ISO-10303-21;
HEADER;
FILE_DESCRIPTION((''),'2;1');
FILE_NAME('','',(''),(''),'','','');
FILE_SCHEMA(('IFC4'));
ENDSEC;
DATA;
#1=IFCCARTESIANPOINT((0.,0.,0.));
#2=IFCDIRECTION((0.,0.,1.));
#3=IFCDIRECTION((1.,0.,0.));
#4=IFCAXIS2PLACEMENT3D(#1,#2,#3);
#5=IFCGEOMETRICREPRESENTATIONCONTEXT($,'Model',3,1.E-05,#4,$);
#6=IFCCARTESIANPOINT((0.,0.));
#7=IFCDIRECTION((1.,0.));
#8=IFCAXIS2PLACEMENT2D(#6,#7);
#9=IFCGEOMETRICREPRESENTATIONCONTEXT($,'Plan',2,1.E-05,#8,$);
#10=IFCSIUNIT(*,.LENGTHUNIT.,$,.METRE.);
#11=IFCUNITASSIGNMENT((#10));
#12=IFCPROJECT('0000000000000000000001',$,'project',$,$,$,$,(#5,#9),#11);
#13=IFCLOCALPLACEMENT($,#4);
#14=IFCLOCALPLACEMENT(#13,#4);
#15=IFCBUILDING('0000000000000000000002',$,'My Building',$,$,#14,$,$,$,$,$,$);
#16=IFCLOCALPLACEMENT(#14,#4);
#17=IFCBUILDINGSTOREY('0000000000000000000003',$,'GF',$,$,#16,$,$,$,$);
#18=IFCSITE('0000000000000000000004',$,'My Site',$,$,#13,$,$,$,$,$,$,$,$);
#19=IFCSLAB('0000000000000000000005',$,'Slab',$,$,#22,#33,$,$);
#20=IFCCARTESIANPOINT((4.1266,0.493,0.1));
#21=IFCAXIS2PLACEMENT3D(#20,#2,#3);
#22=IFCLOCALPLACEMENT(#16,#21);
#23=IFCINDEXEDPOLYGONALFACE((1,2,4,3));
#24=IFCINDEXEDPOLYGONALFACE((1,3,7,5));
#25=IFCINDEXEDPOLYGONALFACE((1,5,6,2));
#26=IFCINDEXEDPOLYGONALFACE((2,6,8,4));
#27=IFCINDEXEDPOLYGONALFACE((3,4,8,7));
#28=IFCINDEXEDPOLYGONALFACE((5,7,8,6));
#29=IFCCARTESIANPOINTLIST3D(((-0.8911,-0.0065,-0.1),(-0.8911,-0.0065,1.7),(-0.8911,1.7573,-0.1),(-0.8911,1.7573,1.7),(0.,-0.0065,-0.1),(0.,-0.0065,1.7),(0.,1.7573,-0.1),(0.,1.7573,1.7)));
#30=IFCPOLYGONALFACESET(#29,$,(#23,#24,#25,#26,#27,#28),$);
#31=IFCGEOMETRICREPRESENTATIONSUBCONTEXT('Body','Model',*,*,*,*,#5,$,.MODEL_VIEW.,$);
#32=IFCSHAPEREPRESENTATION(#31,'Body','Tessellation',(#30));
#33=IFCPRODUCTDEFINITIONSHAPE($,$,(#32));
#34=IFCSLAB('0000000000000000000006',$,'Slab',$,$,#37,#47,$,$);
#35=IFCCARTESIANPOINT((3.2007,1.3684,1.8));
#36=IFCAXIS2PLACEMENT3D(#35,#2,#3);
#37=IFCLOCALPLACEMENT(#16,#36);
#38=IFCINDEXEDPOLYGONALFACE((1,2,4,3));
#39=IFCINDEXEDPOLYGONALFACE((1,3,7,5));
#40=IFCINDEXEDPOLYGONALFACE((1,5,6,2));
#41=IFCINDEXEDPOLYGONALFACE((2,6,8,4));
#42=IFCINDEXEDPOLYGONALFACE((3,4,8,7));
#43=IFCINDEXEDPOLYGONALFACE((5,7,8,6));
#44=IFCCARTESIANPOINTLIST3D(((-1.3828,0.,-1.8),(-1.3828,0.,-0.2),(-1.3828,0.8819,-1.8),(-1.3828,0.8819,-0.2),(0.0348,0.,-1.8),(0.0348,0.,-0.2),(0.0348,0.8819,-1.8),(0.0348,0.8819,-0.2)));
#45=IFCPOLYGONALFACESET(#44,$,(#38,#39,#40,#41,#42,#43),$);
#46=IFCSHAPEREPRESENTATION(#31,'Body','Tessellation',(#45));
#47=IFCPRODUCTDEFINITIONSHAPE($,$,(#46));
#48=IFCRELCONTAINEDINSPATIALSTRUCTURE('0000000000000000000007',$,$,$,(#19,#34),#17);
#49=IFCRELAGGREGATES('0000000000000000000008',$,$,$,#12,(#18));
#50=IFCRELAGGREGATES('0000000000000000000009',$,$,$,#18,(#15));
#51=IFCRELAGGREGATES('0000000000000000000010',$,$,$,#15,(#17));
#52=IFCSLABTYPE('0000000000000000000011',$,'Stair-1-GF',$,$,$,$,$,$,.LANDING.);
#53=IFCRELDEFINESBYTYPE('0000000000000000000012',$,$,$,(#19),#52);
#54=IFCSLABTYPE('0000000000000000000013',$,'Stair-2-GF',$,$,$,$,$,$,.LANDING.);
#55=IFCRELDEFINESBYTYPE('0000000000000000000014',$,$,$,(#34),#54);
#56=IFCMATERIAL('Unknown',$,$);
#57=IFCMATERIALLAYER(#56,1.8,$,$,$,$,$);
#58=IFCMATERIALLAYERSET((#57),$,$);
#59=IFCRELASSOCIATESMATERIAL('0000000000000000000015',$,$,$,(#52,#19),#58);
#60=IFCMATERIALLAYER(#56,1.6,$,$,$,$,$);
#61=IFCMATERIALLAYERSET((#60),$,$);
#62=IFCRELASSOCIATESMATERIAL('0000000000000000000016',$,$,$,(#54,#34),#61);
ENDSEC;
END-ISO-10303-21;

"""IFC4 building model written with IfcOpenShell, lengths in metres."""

from ifc_helpers import new_model, si_unit, frame, origin_with_axes, origin_2d_with_axis, place, context, subcontext, project, spatial, indexed_curve, outline, extrude, material, layer, layer_set, layer_usage, type_object, element, save


model = new_model("IFC4")

# Units and contexts
model_context = context("Model", 3, precision=1e-05, world=origin_with_axes())
plan_context = context("Plan", 2, precision=1e-05, world=origin_2d_with_axis())
body_context_1 = subcontext(model_context, "Body", "Model", "MODEL_VIEW")
ifc_project = project(units=[si_unit("LENGTHUNIT", "METRE")], contexts=[model_context, plan_context])

# Site, building, storey
site_placement = place(None, origin_with_axes())
site = spatial("IfcSite", under=ifc_project, at=site_placement, Name="My Site")
building_placement = place(site_placement, origin_with_axes())
building = spatial("IfcBuilding", under=site, at=building_placement, Name="My Building")
storey_placement = place(building_placement, origin_with_axes())
storey = spatial("IfcBuildingStorey", under=building, at=storey_placement, Name="GF")

# Shared definitions
ifc_material = material(Name="Unknown")

# Slabs
ifc_layer_1 = layer(ifc_material, 1.8)
ifc_layer_set_1 = layer_set([ifc_layer_1])
ifc_layer_usage_1 = layer_usage(ifc_layer_set_1, "AXIS3", "POSITIVE", -0.1)
slab_type_1 = type_object("IfcSlabType", Name="Stair-1-GF", PredefinedType="LANDING", material=ifc_layer_set_1)
slab_1_placement = place(storey_placement, frame((4.1266, 0.493, 0.1), z_axis=(0.0, 0.0, 1.0), x_axis=(1.0, 0.0, 0.0)))
element("IfcSlab", 1, at=slab_1_placement, inside=storey, type_object=slab_type_1, material=ifc_layer_usage_1, Name="Slab", context=body_context_1, shape_type="SweptSolid", body=[
    extrude(outline(indexed_curve([(0.0, -0.0065), (0.0, 1.7573), (-0.8911, 1.7573), (-0.8911, -0.0065), (0.0, -0.0065)])), frame((0.0, 0.0, -0.1), z_axis=(0.0, 0.0, 1.0), x_axis=(1.0, 0.0, 0.0)), (0.0, 0.0, 1.0), 1.8),
])
ifc_layer_2 = layer(ifc_material, 1.6)
ifc_layer_set_2 = layer_set([ifc_layer_2])
ifc_layer_usage_2 = layer_usage(ifc_layer_set_2, "AXIS3", "POSITIVE", -1.8)
slab_type_2 = type_object("IfcSlabType", Name="Stair-2-GF", PredefinedType="LANDING", material=ifc_layer_set_2)
slab_2_placement = place(storey_placement, frame((3.2007, 1.3684, 1.8), z_axis=(0.0, 0.0, 1.0), x_axis=(1.0, 0.0, 0.0)))
element("IfcSlab", 2, at=slab_2_placement, inside=storey, type_object=slab_type_2, material=ifc_layer_usage_2, Name="Slab", context=body_context_1, shape_type="SweptSolid", body=[
    extrude(outline(indexed_curve([(-1.3828, 0.0), (-1.3828, 0.8819), (0.0348, 0.8819), (0.0348, 0.0), (-1.3828, 0.0)])), frame((0.0, 0.0, -1.8), z_axis=(0.0, 0.0, 1.0), x_axis=(1.0, 0.0, 0.0)), (0.0, 0.0, 1.0), 1.6),
])

save(model, "model.ifc")
